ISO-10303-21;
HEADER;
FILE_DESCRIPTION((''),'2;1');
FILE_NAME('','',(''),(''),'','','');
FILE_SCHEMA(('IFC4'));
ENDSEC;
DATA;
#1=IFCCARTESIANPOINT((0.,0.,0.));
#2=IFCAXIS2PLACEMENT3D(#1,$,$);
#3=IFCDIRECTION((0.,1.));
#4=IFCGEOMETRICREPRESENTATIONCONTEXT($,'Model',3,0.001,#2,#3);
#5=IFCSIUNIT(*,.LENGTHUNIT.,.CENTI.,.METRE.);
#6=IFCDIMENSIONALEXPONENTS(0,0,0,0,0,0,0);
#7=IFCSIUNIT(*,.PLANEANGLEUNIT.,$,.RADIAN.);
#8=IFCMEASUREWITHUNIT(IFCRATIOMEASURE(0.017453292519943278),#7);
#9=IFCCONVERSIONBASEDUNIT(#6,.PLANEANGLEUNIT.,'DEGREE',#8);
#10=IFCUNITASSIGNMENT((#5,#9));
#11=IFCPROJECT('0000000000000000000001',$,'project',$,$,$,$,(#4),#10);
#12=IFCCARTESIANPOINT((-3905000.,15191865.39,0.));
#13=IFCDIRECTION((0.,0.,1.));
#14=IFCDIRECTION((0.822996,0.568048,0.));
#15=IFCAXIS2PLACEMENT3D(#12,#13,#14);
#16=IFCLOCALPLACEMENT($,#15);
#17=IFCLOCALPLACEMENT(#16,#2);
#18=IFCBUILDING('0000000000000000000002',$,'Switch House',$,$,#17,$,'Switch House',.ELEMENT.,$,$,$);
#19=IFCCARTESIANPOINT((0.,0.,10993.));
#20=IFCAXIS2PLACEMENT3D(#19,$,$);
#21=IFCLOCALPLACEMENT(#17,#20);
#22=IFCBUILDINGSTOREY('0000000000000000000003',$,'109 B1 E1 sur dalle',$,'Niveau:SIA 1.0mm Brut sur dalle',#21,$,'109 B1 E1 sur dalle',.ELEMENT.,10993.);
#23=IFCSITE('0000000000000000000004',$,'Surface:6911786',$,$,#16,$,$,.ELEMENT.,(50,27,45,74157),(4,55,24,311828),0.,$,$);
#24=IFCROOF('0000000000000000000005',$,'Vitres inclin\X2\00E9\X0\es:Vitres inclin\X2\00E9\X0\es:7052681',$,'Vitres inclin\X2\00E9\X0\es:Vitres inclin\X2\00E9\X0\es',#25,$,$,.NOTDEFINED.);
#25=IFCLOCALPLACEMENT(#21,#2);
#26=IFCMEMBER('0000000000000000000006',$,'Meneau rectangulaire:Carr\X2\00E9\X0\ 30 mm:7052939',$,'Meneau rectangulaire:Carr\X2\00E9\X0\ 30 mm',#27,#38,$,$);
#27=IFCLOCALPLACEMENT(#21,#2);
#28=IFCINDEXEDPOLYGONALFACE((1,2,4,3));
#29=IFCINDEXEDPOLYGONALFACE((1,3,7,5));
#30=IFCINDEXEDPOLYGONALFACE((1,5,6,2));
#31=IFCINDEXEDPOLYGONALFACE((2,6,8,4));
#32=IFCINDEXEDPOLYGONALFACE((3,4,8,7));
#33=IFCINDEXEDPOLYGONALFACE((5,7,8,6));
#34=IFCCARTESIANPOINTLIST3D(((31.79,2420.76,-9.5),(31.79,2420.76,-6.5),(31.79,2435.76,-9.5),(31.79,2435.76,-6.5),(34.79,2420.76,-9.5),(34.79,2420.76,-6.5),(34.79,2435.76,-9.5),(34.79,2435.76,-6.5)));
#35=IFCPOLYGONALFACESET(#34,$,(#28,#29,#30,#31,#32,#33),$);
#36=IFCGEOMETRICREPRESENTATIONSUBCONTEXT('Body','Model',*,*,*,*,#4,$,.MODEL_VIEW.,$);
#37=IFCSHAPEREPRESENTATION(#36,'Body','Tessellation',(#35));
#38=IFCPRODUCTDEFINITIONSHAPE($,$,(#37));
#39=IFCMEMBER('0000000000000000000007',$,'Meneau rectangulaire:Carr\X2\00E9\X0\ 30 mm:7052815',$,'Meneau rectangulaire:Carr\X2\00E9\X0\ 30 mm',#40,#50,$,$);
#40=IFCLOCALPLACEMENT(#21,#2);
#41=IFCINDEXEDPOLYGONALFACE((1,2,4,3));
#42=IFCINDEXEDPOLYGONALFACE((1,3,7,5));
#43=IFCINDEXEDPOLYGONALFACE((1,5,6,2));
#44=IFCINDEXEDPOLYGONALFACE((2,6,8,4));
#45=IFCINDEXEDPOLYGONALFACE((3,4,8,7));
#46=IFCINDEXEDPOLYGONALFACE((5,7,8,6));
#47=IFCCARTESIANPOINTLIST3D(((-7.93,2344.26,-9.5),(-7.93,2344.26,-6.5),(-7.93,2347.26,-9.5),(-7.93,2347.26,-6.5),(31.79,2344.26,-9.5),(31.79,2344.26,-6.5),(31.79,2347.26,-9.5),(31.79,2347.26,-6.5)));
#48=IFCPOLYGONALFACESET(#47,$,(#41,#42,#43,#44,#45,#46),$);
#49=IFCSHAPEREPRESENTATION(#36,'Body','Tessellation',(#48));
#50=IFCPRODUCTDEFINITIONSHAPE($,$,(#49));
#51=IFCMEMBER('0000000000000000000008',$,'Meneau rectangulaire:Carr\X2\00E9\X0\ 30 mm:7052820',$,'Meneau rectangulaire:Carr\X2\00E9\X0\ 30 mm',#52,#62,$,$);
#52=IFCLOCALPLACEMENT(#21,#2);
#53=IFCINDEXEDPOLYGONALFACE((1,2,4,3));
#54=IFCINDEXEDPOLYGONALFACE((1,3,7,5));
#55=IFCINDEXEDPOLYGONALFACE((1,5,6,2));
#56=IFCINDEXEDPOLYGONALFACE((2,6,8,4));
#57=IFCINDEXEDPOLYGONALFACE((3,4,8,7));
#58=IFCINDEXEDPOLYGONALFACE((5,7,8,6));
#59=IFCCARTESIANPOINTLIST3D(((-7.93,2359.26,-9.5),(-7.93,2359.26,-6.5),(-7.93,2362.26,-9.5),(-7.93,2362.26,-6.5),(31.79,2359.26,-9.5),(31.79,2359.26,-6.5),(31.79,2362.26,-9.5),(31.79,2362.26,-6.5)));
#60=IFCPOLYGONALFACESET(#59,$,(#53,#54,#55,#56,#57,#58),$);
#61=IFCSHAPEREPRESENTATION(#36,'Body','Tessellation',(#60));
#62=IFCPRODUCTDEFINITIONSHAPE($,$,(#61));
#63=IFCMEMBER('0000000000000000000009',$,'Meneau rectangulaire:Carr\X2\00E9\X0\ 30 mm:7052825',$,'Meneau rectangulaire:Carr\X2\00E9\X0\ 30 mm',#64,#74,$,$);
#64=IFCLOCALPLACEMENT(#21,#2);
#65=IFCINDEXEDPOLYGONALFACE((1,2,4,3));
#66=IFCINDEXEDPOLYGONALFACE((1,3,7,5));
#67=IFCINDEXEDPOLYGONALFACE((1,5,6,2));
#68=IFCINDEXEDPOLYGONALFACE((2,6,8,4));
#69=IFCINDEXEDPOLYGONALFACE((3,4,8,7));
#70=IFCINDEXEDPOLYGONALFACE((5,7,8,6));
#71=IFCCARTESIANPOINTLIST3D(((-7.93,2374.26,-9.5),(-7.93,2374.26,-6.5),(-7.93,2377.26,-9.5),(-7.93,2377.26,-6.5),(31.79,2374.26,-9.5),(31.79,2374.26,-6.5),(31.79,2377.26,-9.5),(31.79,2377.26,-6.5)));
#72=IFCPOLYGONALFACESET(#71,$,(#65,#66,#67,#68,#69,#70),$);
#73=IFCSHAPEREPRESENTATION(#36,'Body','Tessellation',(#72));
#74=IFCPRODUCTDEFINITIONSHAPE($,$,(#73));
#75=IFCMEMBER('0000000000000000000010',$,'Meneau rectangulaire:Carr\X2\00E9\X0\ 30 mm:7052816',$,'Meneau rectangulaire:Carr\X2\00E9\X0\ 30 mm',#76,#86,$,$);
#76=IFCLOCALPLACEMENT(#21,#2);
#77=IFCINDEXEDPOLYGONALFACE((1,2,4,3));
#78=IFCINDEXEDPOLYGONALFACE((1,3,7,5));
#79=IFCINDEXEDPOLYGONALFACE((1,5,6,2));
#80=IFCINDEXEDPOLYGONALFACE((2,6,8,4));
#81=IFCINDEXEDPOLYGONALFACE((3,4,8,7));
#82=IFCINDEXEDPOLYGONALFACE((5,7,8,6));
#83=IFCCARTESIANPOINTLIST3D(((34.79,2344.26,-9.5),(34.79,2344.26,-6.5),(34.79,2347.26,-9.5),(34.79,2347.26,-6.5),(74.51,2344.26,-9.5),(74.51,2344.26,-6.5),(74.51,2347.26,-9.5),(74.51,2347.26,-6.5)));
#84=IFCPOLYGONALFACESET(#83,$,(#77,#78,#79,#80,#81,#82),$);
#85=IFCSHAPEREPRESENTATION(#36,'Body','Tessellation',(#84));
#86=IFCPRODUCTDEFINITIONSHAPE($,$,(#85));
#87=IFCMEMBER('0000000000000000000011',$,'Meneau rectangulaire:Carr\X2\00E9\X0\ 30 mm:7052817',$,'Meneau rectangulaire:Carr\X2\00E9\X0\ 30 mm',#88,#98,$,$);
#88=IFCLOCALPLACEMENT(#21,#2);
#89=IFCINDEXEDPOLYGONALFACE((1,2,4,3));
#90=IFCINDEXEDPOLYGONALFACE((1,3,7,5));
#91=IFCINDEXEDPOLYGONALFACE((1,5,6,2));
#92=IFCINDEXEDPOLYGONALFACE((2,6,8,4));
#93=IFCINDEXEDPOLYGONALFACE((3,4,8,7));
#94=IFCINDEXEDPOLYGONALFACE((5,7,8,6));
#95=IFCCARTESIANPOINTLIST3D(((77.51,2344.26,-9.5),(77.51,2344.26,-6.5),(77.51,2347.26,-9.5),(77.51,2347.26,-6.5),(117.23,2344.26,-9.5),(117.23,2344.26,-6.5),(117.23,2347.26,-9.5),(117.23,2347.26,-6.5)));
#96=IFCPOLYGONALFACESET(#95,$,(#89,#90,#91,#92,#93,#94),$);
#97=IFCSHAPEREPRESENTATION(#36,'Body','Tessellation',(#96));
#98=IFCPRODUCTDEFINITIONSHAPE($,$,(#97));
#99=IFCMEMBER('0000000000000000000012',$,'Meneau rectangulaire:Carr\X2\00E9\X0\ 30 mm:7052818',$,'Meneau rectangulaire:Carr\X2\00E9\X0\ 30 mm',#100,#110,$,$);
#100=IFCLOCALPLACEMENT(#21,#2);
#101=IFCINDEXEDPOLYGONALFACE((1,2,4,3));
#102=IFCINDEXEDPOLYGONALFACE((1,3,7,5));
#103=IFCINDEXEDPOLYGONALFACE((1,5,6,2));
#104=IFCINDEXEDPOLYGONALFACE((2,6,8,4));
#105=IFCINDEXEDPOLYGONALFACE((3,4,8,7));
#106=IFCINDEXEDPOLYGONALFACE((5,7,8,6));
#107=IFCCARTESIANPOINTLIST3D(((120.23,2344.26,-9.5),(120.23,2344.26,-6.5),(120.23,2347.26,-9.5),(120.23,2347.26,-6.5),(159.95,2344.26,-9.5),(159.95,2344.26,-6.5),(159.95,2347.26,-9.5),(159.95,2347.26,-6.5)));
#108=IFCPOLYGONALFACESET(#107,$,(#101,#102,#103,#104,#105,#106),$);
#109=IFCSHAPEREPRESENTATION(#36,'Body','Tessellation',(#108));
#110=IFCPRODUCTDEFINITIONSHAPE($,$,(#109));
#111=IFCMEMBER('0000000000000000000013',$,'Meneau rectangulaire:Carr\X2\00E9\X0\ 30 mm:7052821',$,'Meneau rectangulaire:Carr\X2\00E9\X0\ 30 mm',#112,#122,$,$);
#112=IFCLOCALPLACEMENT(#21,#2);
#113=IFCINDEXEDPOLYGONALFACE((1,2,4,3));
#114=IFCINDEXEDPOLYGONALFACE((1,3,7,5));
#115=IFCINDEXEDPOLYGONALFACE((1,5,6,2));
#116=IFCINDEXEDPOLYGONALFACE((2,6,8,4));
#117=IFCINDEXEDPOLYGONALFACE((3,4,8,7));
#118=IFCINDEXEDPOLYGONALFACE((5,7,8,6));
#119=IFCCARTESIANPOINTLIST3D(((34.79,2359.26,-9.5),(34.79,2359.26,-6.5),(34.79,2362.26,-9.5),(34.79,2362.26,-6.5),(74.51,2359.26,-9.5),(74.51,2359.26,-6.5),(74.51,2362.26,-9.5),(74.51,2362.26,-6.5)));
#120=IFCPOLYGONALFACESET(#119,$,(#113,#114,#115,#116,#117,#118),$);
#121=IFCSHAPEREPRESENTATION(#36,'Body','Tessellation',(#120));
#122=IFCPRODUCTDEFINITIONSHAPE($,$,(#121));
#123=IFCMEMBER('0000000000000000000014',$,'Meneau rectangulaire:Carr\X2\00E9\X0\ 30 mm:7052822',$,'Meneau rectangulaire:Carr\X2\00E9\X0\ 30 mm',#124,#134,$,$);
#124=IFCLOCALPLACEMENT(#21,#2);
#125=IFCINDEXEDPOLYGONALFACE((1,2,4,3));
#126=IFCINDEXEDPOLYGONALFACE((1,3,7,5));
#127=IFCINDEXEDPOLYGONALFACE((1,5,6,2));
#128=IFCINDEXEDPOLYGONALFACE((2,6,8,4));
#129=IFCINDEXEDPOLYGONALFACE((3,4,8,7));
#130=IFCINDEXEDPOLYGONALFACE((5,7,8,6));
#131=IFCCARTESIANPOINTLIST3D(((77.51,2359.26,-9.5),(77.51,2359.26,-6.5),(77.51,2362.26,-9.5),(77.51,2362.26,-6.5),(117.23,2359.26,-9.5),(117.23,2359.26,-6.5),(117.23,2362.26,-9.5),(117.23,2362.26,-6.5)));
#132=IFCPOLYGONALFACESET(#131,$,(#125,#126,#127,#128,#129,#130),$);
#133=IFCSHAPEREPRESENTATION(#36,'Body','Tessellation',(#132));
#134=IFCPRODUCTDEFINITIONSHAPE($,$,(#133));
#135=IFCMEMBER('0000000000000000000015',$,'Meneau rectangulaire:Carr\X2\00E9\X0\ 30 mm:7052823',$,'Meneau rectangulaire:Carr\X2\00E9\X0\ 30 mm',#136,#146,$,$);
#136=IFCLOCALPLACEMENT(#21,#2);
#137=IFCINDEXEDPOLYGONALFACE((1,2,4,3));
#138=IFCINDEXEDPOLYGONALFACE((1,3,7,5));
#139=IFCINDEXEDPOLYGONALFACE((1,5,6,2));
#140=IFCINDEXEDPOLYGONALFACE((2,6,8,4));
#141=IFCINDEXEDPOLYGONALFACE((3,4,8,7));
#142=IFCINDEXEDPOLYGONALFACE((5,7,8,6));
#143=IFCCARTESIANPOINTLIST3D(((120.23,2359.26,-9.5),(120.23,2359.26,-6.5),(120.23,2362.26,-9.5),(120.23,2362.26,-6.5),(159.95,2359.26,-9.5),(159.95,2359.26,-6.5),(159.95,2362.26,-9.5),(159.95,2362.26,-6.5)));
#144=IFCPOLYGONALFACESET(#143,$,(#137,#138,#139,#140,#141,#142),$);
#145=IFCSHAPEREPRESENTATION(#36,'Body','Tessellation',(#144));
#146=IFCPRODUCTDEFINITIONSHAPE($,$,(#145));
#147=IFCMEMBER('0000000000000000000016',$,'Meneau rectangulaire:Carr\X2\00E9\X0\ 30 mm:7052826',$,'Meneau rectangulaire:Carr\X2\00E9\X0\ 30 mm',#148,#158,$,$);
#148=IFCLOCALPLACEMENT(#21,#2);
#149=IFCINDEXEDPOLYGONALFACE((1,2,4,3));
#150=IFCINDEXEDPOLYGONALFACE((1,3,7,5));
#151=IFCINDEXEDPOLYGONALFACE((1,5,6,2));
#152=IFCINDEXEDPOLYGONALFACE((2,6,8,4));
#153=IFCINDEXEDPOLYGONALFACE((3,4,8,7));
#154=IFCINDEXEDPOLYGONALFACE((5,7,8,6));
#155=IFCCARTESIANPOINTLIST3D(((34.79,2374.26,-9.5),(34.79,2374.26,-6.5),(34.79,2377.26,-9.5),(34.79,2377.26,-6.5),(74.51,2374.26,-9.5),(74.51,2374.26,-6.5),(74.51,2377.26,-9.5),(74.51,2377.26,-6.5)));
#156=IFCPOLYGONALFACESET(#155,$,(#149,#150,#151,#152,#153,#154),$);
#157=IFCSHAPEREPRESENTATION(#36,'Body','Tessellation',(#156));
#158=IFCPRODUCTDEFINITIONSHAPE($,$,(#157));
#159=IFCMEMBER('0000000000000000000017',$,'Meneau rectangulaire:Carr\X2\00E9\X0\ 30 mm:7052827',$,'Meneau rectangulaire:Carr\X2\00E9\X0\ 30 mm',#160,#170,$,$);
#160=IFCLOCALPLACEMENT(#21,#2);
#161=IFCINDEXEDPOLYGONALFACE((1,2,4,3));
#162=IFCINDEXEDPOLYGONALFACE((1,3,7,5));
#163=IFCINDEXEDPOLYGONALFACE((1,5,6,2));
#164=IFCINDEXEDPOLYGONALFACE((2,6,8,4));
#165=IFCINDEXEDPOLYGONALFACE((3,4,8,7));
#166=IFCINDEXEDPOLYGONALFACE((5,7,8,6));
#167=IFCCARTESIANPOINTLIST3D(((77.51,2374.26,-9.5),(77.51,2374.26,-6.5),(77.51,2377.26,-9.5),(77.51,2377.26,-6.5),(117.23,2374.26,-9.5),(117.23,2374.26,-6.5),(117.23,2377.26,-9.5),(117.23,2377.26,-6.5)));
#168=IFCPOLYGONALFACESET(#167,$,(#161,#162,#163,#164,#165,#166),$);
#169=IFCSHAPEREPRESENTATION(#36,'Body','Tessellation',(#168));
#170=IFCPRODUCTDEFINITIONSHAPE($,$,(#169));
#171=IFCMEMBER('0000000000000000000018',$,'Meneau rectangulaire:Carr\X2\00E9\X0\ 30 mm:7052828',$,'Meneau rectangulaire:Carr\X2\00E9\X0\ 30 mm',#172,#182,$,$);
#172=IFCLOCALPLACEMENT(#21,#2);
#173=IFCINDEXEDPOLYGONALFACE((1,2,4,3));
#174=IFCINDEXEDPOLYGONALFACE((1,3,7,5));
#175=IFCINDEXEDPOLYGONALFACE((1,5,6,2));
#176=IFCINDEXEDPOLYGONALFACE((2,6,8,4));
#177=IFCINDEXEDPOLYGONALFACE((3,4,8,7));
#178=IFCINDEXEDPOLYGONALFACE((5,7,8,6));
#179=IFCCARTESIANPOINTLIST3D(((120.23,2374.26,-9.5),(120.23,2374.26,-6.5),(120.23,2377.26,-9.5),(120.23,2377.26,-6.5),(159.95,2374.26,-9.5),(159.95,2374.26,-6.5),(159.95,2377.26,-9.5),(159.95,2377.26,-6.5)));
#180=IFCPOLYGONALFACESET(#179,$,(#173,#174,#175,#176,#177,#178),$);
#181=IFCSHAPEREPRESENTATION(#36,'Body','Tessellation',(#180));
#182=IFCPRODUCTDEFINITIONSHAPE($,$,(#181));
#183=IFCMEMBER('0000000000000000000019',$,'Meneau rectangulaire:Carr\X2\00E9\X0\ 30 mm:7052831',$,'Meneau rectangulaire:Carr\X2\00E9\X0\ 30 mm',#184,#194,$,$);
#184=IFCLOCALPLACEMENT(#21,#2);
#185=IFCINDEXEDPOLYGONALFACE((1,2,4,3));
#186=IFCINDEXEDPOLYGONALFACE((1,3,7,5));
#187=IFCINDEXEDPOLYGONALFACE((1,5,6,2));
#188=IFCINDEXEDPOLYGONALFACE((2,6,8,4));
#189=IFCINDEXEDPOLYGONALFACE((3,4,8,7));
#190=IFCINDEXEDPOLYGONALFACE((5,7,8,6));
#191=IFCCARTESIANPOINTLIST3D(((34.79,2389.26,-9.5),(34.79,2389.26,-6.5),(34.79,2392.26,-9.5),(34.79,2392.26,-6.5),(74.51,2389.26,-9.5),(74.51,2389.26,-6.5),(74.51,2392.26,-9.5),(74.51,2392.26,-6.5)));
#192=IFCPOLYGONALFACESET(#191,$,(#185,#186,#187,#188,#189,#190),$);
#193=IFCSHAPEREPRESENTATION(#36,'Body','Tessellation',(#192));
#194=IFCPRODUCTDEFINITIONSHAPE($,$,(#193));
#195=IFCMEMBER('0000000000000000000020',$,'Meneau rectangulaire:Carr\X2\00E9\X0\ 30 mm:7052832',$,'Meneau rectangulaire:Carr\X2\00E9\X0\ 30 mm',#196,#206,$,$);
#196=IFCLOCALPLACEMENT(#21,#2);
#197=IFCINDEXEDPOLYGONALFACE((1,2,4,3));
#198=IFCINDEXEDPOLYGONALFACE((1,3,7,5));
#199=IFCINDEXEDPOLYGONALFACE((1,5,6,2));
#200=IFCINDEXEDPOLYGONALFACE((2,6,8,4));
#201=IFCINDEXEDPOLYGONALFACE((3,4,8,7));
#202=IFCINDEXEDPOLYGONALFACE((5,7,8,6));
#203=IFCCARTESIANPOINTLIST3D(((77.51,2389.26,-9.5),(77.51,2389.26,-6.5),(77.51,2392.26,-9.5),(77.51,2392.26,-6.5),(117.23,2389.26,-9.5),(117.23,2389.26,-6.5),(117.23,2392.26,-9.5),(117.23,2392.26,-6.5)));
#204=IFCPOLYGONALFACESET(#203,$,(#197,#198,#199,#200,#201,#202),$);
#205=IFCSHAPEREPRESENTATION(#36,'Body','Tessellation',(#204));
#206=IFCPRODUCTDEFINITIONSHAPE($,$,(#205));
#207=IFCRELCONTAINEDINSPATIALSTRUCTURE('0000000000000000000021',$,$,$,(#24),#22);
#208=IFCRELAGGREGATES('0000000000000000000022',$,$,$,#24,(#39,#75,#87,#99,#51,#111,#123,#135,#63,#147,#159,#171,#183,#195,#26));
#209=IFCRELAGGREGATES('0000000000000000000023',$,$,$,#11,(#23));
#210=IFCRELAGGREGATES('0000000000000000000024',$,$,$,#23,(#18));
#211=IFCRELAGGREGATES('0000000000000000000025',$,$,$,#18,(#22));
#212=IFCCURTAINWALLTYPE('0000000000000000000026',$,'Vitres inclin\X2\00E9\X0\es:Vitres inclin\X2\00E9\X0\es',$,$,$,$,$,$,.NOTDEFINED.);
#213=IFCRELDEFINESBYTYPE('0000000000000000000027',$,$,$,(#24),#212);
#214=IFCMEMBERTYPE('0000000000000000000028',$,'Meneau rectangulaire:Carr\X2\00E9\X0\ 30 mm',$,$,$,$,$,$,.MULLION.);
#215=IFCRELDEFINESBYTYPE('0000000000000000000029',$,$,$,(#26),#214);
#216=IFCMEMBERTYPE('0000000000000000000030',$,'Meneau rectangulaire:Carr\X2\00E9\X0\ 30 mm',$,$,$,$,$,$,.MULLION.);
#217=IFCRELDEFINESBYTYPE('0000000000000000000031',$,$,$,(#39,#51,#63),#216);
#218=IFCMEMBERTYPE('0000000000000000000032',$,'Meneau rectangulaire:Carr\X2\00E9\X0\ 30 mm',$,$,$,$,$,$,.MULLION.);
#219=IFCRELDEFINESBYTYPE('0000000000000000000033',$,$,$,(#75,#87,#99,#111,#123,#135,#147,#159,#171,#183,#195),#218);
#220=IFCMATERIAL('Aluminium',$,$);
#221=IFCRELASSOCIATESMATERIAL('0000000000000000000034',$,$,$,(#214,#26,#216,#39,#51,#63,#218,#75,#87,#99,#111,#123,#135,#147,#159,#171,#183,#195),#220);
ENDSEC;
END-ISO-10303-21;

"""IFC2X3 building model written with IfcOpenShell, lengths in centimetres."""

from ifc_helpers import new_model, entity, si_unit, converted_unit, direction, frame, origin, origin_2d_with_axis, place, context, subcontext, project, spatial, rectangle, extrude, source, transform, mapped, material, type_object, type_shapes, element, aggregate, save


model = new_model("IFC2X3")

# Units and contexts
model_context = context("Model", 3, precision=0.001, world=origin(), true_north=direction((0.0, 1.0)))
body_context = subcontext(model_context, "Body", "Model", "MODEL_VIEW")
ifc_project = project(units=[si_unit("LENGTHUNIT", "METRE", prefix="CENTI"), converted_unit("PLANEANGLEUNIT", "DEGREE", entity("IfcRatioMeasure", 0.017453292519943278), si_unit("PLANEANGLEUNIT", "RADIAN"), dimensions=[0, 0, 0, 0, 0, 0, 0])], contexts=[model_context])

# Site, building, storey
site_placement = place(None, frame((-3905000.0, 15191865.39, 0.0), z_axis=(0.0, 0.0, 1.0), x_axis=(0.822996, 0.568048, 0.0)))
site = spatial("IfcSite", under=ifc_project, at=site_placement, Name="Surface:6911786", CompositionType="ELEMENT", RefLatitude=(50, 27, 45, 74157), RefLongitude=(4, 55, 24, 311828), RefElevation=0.0)
building_placement = place(site_placement, origin())
building = spatial("IfcBuilding", under=site, at=building_placement, Name="Switch House", LongName="Switch House", CompositionType="ELEMENT")
storey_placement = place(building_placement, frame((0.0, 0.0, 10993.0)))
storey = spatial("IfcBuildingStorey", under=building, at=storey_placement, Name="109 B1 E1 sur dalle", ObjectType="Niveau:SIA 1.0mm Brut sur dalle", LongName="109 B1 E1 sur dalle", CompositionType="ELEMENT", Elevation=10993.0)

# Roof, members
curtain_wall_type = type_object("IfcCurtainWallType", Name="Vitres inclinées:Vitres inclinées", PredefinedType="NOTDEFINED")
roof_placement = place(storey_placement, frame((0.0, 0.0, -10993.0)))
roof = element("IfcRoof", 1, at=roof_placement, inside=storey, type_object=curtain_wall_type, Name="Vitres inclinées:Vitres inclinées:7052681", ObjectType="Vitres inclinées:Vitres inclinées", ShapeType="NOTDEFINED")
ifc_material = material(Name="Aluminium")
member_type_1 = type_object("IfcMemberType", Name="Meneau rectangulaire:Carré 30 mm", PredefinedType="MULLION", material=ifc_material)
shared_shape_1 = source(origin(), body_context, "Body", "SweptSolid", [
    extrude(rectangle(XDim=3.0, YDim=3.0, at=origin_2d_with_axis()), frame((0.0, 0.0, -15.0), z_axis=(0.0, 0.0, 1.0), x_axis=(0.0, -1.0, 0.0)), (0.0, 0.0, 1.0), 15.0),
])
type_shapes(member_type_1, [shared_shape_1])
member_1_placement = place(roof_placement, frame((33.29, 2435.76, 10985.0), z_axis=(0.0, 1.0, 0.0), x_axis=(1.0, 0.0, 0.0)))
member_1 = element("IfcMember", 2, at=member_1_placement, type_object=member_type_1, material=ifc_material, Name="Meneau rectangulaire:Carré 30 mm:7052939", ObjectType="Meneau rectangulaire:Carré 30 mm", context=body_context, shape_type="MappedRepresentation", body=[
    mapped(shared_shape_1, transform((0.0, 0.0, 0.0), scale=1.0)),
])
member_type_2 = type_object("IfcMemberType", Name="Meneau rectangulaire:Carré 30 mm", PredefinedType="MULLION", material=ifc_material)
shared_shape_2 = source(origin(), body_context, "Body", "SweptSolid", [
    extrude(rectangle(XDim=3.0, YDim=3.0, at=origin_2d_with_axis()), frame((0.0, 0.0, -39.72), z_axis=(0.0, 0.0, 1.0), x_axis=(0.0, -1.0, 0.0)), (0.0, 0.0, 1.0), 39.72),
])
type_shapes(member_type_2, [shared_shape_2])
member_2_placement = place(roof_placement, frame((-7.93, 2345.76, 10985.0), z_axis=(-1.0, 0.0, 0.0), x_axis=(0.0, 1.0, 0.0)))
member_2 = element("IfcMember", 3, at=member_2_placement, type_object=member_type_2, material=ifc_material, Name="Meneau rectangulaire:Carré 30 mm:7052815", ObjectType="Meneau rectangulaire:Carré 30 mm", context=body_context, shape_type="MappedRepresentation", body=[
    mapped(shared_shape_2, transform((0.0, 0.0, 0.0), scale=1.0)),
])
member_3_placement = place(roof_placement, frame((-7.93, 2360.76, 10985.0), z_axis=(-1.0, 0.0, 0.0), x_axis=(0.0, 1.0, 0.0)))
member_3 = element("IfcMember", 4, at=member_3_placement, type_object=member_type_2, material=ifc_material, Name="Meneau rectangulaire:Carré 30 mm:7052820", ObjectType="Meneau rectangulaire:Carré 30 mm", context=body_context, shape_type="MappedRepresentation", body=[
    mapped(shared_shape_2, transform((0.0, 0.0, 0.0), scale=1.0)),
])
member_4_placement = place(roof_placement, frame((-7.93, 2375.76, 10985.0), z_axis=(-1.0, 0.0, 0.0), x_axis=(0.0, 1.0, 0.0)))
member_4 = element("IfcMember", 5, at=member_4_placement, type_object=member_type_2, material=ifc_material, Name="Meneau rectangulaire:Carré 30 mm:7052825", ObjectType="Meneau rectangulaire:Carré 30 mm", context=body_context, shape_type="MappedRepresentation", body=[
    mapped(shared_shape_2, transform((0.0, 0.0, 0.0), scale=1.0)),
])
member_type_3 = type_object("IfcMemberType", Name="Meneau rectangulaire:Carré 30 mm", PredefinedType="MULLION", material=ifc_material)
shared_shape_3 = source(origin(), body_context, "Body", "SweptSolid", [
    extrude(rectangle(XDim=3.0, YDim=3.0, at=origin_2d_with_axis()), frame((0.0, 0.0, -39.72), z_axis=(0.0, 0.0, 1.0), x_axis=(0.0, -1.0, 0.0)), (0.0, 0.0, 1.0), 39.72),
])
type_shapes(member_type_3, [shared_shape_3])
member_5_placement = place(roof_placement, frame((34.79, 2345.76, 10985.0), z_axis=(-1.0, 0.0, 0.0), x_axis=(0.0, 1.0, 0.0)))
member_5 = element("IfcMember", 6, at=member_5_placement, type_object=member_type_3, material=ifc_material, Name="Meneau rectangulaire:Carré 30 mm:7052816", ObjectType="Meneau rectangulaire:Carré 30 mm", context=body_context, shape_type="MappedRepresentation", body=[
    mapped(shared_shape_3, transform((0.0, 0.0, 0.0), scale=1.0)),
])
member_6_placement = place(roof_placement, frame((77.51, 2345.76, 10985.0), z_axis=(-1.0, 0.0, 0.0), x_axis=(0.0, 1.0, 0.0)))
member_6 = element("IfcMember", 7, at=member_6_placement, type_object=member_type_3, material=ifc_material, Name="Meneau rectangulaire:Carré 30 mm:7052817", ObjectType="Meneau rectangulaire:Carré 30 mm", context=body_context, shape_type="MappedRepresentation", body=[
    mapped(shared_shape_3, transform((0.0, 0.0, 0.0), scale=1.0)),
])
member_7_placement = place(roof_placement, frame((120.23, 2345.76, 10985.0), z_axis=(-1.0, 0.0, 0.0), x_axis=(0.0, 1.0, 0.0)))
member_7 = element("IfcMember", 8, at=member_7_placement, type_object=member_type_3, material=ifc_material, Name="Meneau rectangulaire:Carré 30 mm:7052818", ObjectType="Meneau rectangulaire:Carré 30 mm", context=body_context, shape_type="MappedRepresentation", body=[
    mapped(shared_shape_3, transform((0.0, 0.0, 0.0), scale=1.0)),
])
member_8_placement = place(roof_placement, frame((34.79, 2360.76, 10985.0), z_axis=(-1.0, 0.0, 0.0), x_axis=(0.0, 1.0, 0.0)))
member_8 = element("IfcMember", 9, at=member_8_placement, type_object=member_type_3, material=ifc_material, Name="Meneau rectangulaire:Carré 30 mm:7052821", ObjectType="Meneau rectangulaire:Carré 30 mm", context=body_context, shape_type="MappedRepresentation", body=[
    mapped(shared_shape_3, transform((0.0, 0.0, 0.0), scale=1.0)),
])
member_9_placement = place(roof_placement, frame((77.51, 2360.76, 10985.0), z_axis=(-1.0, 0.0, 0.0), x_axis=(0.0, 1.0, 0.0)))
member_9 = element("IfcMember", 10, at=member_9_placement, type_object=member_type_3, material=ifc_material, Name="Meneau rectangulaire:Carré 30 mm:7052822", ObjectType="Meneau rectangulaire:Carré 30 mm", context=body_context, shape_type="MappedRepresentation", body=[
    mapped(shared_shape_3, transform((0.0, 0.0, 0.0), scale=1.0)),
])
member_10_placement = place(roof_placement, frame((120.23, 2360.76, 10985.0), z_axis=(-1.0, 0.0, 0.0), x_axis=(0.0, 1.0, 0.0)))
member_10 = element("IfcMember", 11, at=member_10_placement, type_object=member_type_3, material=ifc_material, Name="Meneau rectangulaire:Carré 30 mm:7052823", ObjectType="Meneau rectangulaire:Carré 30 mm", context=body_context, shape_type="MappedRepresentation", body=[
    mapped(shared_shape_3, transform((0.0, 0.0, 0.0), scale=1.0)),
])
member_11_placement = place(roof_placement, frame((34.79, 2375.76, 10985.0), z_axis=(-1.0, 0.0, 0.0), x_axis=(0.0, 1.0, 0.0)))
member_11 = element("IfcMember", 12, at=member_11_placement, type_object=member_type_3, material=ifc_material, Name="Meneau rectangulaire:Carré 30 mm:7052826", ObjectType="Meneau rectangulaire:Carré 30 mm", context=body_context, shape_type="MappedRepresentation", body=[
    mapped(shared_shape_3, transform((0.0, 0.0, 0.0), scale=1.0)),
])
member_12_placement = place(roof_placement, frame((77.51, 2375.76, 10985.0), z_axis=(-1.0, 0.0, 0.0), x_axis=(0.0, 1.0, 0.0)))
member_12 = element("IfcMember", 13, at=member_12_placement, type_object=member_type_3, material=ifc_material, Name="Meneau rectangulaire:Carré 30 mm:7052827", ObjectType="Meneau rectangulaire:Carré 30 mm", context=body_context, shape_type="MappedRepresentation", body=[
    mapped(shared_shape_3, transform((0.0, 0.0, 0.0), scale=1.0)),
])
member_13_placement = place(roof_placement, frame((120.23, 2375.76, 10985.0), z_axis=(-1.0, 0.0, 0.0), x_axis=(0.0, 1.0, 0.0)))
member_13 = element("IfcMember", 14, at=member_13_placement, type_object=member_type_3, material=ifc_material, Name="Meneau rectangulaire:Carré 30 mm:7052828", ObjectType="Meneau rectangulaire:Carré 30 mm", context=body_context, shape_type="MappedRepresentation", body=[
    mapped(shared_shape_3, transform((0.0, 0.0, 0.0), scale=1.0)),
])
member_14_placement = place(roof_placement, frame((34.79, 2390.76, 10985.0), z_axis=(-1.0, 0.0, 0.0), x_axis=(0.0, 1.0, 0.0)))
member_14 = element("IfcMember", 15, at=member_14_placement, type_object=member_type_3, material=ifc_material, Name="Meneau rectangulaire:Carré 30 mm:7052831", ObjectType="Meneau rectangulaire:Carré 30 mm", context=body_context, shape_type="MappedRepresentation", body=[
    mapped(shared_shape_3, transform((0.0, 0.0, 0.0), scale=1.0)),
])
member_15_placement = place(roof_placement, frame((77.51, 2390.76, 10985.0), z_axis=(-1.0, 0.0, 0.0), x_axis=(0.0, 1.0, 0.0)))
member_15 = element("IfcMember", 16, at=member_15_placement, type_object=member_type_3, material=ifc_material, Name="Meneau rectangulaire:Carré 30 mm:7052832", ObjectType="Meneau rectangulaire:Carré 30 mm", context=body_context, shape_type="MappedRepresentation", body=[
    mapped(shared_shape_3, transform((0.0, 0.0, 0.0), scale=1.0)),
])
aggregate(roof, [member_2, member_5, member_6, member_7, member_3, member_8, member_9, member_10, member_4, member_11, member_12, member_13, member_14, member_15, member_1])

save(model, "model.ifc")
